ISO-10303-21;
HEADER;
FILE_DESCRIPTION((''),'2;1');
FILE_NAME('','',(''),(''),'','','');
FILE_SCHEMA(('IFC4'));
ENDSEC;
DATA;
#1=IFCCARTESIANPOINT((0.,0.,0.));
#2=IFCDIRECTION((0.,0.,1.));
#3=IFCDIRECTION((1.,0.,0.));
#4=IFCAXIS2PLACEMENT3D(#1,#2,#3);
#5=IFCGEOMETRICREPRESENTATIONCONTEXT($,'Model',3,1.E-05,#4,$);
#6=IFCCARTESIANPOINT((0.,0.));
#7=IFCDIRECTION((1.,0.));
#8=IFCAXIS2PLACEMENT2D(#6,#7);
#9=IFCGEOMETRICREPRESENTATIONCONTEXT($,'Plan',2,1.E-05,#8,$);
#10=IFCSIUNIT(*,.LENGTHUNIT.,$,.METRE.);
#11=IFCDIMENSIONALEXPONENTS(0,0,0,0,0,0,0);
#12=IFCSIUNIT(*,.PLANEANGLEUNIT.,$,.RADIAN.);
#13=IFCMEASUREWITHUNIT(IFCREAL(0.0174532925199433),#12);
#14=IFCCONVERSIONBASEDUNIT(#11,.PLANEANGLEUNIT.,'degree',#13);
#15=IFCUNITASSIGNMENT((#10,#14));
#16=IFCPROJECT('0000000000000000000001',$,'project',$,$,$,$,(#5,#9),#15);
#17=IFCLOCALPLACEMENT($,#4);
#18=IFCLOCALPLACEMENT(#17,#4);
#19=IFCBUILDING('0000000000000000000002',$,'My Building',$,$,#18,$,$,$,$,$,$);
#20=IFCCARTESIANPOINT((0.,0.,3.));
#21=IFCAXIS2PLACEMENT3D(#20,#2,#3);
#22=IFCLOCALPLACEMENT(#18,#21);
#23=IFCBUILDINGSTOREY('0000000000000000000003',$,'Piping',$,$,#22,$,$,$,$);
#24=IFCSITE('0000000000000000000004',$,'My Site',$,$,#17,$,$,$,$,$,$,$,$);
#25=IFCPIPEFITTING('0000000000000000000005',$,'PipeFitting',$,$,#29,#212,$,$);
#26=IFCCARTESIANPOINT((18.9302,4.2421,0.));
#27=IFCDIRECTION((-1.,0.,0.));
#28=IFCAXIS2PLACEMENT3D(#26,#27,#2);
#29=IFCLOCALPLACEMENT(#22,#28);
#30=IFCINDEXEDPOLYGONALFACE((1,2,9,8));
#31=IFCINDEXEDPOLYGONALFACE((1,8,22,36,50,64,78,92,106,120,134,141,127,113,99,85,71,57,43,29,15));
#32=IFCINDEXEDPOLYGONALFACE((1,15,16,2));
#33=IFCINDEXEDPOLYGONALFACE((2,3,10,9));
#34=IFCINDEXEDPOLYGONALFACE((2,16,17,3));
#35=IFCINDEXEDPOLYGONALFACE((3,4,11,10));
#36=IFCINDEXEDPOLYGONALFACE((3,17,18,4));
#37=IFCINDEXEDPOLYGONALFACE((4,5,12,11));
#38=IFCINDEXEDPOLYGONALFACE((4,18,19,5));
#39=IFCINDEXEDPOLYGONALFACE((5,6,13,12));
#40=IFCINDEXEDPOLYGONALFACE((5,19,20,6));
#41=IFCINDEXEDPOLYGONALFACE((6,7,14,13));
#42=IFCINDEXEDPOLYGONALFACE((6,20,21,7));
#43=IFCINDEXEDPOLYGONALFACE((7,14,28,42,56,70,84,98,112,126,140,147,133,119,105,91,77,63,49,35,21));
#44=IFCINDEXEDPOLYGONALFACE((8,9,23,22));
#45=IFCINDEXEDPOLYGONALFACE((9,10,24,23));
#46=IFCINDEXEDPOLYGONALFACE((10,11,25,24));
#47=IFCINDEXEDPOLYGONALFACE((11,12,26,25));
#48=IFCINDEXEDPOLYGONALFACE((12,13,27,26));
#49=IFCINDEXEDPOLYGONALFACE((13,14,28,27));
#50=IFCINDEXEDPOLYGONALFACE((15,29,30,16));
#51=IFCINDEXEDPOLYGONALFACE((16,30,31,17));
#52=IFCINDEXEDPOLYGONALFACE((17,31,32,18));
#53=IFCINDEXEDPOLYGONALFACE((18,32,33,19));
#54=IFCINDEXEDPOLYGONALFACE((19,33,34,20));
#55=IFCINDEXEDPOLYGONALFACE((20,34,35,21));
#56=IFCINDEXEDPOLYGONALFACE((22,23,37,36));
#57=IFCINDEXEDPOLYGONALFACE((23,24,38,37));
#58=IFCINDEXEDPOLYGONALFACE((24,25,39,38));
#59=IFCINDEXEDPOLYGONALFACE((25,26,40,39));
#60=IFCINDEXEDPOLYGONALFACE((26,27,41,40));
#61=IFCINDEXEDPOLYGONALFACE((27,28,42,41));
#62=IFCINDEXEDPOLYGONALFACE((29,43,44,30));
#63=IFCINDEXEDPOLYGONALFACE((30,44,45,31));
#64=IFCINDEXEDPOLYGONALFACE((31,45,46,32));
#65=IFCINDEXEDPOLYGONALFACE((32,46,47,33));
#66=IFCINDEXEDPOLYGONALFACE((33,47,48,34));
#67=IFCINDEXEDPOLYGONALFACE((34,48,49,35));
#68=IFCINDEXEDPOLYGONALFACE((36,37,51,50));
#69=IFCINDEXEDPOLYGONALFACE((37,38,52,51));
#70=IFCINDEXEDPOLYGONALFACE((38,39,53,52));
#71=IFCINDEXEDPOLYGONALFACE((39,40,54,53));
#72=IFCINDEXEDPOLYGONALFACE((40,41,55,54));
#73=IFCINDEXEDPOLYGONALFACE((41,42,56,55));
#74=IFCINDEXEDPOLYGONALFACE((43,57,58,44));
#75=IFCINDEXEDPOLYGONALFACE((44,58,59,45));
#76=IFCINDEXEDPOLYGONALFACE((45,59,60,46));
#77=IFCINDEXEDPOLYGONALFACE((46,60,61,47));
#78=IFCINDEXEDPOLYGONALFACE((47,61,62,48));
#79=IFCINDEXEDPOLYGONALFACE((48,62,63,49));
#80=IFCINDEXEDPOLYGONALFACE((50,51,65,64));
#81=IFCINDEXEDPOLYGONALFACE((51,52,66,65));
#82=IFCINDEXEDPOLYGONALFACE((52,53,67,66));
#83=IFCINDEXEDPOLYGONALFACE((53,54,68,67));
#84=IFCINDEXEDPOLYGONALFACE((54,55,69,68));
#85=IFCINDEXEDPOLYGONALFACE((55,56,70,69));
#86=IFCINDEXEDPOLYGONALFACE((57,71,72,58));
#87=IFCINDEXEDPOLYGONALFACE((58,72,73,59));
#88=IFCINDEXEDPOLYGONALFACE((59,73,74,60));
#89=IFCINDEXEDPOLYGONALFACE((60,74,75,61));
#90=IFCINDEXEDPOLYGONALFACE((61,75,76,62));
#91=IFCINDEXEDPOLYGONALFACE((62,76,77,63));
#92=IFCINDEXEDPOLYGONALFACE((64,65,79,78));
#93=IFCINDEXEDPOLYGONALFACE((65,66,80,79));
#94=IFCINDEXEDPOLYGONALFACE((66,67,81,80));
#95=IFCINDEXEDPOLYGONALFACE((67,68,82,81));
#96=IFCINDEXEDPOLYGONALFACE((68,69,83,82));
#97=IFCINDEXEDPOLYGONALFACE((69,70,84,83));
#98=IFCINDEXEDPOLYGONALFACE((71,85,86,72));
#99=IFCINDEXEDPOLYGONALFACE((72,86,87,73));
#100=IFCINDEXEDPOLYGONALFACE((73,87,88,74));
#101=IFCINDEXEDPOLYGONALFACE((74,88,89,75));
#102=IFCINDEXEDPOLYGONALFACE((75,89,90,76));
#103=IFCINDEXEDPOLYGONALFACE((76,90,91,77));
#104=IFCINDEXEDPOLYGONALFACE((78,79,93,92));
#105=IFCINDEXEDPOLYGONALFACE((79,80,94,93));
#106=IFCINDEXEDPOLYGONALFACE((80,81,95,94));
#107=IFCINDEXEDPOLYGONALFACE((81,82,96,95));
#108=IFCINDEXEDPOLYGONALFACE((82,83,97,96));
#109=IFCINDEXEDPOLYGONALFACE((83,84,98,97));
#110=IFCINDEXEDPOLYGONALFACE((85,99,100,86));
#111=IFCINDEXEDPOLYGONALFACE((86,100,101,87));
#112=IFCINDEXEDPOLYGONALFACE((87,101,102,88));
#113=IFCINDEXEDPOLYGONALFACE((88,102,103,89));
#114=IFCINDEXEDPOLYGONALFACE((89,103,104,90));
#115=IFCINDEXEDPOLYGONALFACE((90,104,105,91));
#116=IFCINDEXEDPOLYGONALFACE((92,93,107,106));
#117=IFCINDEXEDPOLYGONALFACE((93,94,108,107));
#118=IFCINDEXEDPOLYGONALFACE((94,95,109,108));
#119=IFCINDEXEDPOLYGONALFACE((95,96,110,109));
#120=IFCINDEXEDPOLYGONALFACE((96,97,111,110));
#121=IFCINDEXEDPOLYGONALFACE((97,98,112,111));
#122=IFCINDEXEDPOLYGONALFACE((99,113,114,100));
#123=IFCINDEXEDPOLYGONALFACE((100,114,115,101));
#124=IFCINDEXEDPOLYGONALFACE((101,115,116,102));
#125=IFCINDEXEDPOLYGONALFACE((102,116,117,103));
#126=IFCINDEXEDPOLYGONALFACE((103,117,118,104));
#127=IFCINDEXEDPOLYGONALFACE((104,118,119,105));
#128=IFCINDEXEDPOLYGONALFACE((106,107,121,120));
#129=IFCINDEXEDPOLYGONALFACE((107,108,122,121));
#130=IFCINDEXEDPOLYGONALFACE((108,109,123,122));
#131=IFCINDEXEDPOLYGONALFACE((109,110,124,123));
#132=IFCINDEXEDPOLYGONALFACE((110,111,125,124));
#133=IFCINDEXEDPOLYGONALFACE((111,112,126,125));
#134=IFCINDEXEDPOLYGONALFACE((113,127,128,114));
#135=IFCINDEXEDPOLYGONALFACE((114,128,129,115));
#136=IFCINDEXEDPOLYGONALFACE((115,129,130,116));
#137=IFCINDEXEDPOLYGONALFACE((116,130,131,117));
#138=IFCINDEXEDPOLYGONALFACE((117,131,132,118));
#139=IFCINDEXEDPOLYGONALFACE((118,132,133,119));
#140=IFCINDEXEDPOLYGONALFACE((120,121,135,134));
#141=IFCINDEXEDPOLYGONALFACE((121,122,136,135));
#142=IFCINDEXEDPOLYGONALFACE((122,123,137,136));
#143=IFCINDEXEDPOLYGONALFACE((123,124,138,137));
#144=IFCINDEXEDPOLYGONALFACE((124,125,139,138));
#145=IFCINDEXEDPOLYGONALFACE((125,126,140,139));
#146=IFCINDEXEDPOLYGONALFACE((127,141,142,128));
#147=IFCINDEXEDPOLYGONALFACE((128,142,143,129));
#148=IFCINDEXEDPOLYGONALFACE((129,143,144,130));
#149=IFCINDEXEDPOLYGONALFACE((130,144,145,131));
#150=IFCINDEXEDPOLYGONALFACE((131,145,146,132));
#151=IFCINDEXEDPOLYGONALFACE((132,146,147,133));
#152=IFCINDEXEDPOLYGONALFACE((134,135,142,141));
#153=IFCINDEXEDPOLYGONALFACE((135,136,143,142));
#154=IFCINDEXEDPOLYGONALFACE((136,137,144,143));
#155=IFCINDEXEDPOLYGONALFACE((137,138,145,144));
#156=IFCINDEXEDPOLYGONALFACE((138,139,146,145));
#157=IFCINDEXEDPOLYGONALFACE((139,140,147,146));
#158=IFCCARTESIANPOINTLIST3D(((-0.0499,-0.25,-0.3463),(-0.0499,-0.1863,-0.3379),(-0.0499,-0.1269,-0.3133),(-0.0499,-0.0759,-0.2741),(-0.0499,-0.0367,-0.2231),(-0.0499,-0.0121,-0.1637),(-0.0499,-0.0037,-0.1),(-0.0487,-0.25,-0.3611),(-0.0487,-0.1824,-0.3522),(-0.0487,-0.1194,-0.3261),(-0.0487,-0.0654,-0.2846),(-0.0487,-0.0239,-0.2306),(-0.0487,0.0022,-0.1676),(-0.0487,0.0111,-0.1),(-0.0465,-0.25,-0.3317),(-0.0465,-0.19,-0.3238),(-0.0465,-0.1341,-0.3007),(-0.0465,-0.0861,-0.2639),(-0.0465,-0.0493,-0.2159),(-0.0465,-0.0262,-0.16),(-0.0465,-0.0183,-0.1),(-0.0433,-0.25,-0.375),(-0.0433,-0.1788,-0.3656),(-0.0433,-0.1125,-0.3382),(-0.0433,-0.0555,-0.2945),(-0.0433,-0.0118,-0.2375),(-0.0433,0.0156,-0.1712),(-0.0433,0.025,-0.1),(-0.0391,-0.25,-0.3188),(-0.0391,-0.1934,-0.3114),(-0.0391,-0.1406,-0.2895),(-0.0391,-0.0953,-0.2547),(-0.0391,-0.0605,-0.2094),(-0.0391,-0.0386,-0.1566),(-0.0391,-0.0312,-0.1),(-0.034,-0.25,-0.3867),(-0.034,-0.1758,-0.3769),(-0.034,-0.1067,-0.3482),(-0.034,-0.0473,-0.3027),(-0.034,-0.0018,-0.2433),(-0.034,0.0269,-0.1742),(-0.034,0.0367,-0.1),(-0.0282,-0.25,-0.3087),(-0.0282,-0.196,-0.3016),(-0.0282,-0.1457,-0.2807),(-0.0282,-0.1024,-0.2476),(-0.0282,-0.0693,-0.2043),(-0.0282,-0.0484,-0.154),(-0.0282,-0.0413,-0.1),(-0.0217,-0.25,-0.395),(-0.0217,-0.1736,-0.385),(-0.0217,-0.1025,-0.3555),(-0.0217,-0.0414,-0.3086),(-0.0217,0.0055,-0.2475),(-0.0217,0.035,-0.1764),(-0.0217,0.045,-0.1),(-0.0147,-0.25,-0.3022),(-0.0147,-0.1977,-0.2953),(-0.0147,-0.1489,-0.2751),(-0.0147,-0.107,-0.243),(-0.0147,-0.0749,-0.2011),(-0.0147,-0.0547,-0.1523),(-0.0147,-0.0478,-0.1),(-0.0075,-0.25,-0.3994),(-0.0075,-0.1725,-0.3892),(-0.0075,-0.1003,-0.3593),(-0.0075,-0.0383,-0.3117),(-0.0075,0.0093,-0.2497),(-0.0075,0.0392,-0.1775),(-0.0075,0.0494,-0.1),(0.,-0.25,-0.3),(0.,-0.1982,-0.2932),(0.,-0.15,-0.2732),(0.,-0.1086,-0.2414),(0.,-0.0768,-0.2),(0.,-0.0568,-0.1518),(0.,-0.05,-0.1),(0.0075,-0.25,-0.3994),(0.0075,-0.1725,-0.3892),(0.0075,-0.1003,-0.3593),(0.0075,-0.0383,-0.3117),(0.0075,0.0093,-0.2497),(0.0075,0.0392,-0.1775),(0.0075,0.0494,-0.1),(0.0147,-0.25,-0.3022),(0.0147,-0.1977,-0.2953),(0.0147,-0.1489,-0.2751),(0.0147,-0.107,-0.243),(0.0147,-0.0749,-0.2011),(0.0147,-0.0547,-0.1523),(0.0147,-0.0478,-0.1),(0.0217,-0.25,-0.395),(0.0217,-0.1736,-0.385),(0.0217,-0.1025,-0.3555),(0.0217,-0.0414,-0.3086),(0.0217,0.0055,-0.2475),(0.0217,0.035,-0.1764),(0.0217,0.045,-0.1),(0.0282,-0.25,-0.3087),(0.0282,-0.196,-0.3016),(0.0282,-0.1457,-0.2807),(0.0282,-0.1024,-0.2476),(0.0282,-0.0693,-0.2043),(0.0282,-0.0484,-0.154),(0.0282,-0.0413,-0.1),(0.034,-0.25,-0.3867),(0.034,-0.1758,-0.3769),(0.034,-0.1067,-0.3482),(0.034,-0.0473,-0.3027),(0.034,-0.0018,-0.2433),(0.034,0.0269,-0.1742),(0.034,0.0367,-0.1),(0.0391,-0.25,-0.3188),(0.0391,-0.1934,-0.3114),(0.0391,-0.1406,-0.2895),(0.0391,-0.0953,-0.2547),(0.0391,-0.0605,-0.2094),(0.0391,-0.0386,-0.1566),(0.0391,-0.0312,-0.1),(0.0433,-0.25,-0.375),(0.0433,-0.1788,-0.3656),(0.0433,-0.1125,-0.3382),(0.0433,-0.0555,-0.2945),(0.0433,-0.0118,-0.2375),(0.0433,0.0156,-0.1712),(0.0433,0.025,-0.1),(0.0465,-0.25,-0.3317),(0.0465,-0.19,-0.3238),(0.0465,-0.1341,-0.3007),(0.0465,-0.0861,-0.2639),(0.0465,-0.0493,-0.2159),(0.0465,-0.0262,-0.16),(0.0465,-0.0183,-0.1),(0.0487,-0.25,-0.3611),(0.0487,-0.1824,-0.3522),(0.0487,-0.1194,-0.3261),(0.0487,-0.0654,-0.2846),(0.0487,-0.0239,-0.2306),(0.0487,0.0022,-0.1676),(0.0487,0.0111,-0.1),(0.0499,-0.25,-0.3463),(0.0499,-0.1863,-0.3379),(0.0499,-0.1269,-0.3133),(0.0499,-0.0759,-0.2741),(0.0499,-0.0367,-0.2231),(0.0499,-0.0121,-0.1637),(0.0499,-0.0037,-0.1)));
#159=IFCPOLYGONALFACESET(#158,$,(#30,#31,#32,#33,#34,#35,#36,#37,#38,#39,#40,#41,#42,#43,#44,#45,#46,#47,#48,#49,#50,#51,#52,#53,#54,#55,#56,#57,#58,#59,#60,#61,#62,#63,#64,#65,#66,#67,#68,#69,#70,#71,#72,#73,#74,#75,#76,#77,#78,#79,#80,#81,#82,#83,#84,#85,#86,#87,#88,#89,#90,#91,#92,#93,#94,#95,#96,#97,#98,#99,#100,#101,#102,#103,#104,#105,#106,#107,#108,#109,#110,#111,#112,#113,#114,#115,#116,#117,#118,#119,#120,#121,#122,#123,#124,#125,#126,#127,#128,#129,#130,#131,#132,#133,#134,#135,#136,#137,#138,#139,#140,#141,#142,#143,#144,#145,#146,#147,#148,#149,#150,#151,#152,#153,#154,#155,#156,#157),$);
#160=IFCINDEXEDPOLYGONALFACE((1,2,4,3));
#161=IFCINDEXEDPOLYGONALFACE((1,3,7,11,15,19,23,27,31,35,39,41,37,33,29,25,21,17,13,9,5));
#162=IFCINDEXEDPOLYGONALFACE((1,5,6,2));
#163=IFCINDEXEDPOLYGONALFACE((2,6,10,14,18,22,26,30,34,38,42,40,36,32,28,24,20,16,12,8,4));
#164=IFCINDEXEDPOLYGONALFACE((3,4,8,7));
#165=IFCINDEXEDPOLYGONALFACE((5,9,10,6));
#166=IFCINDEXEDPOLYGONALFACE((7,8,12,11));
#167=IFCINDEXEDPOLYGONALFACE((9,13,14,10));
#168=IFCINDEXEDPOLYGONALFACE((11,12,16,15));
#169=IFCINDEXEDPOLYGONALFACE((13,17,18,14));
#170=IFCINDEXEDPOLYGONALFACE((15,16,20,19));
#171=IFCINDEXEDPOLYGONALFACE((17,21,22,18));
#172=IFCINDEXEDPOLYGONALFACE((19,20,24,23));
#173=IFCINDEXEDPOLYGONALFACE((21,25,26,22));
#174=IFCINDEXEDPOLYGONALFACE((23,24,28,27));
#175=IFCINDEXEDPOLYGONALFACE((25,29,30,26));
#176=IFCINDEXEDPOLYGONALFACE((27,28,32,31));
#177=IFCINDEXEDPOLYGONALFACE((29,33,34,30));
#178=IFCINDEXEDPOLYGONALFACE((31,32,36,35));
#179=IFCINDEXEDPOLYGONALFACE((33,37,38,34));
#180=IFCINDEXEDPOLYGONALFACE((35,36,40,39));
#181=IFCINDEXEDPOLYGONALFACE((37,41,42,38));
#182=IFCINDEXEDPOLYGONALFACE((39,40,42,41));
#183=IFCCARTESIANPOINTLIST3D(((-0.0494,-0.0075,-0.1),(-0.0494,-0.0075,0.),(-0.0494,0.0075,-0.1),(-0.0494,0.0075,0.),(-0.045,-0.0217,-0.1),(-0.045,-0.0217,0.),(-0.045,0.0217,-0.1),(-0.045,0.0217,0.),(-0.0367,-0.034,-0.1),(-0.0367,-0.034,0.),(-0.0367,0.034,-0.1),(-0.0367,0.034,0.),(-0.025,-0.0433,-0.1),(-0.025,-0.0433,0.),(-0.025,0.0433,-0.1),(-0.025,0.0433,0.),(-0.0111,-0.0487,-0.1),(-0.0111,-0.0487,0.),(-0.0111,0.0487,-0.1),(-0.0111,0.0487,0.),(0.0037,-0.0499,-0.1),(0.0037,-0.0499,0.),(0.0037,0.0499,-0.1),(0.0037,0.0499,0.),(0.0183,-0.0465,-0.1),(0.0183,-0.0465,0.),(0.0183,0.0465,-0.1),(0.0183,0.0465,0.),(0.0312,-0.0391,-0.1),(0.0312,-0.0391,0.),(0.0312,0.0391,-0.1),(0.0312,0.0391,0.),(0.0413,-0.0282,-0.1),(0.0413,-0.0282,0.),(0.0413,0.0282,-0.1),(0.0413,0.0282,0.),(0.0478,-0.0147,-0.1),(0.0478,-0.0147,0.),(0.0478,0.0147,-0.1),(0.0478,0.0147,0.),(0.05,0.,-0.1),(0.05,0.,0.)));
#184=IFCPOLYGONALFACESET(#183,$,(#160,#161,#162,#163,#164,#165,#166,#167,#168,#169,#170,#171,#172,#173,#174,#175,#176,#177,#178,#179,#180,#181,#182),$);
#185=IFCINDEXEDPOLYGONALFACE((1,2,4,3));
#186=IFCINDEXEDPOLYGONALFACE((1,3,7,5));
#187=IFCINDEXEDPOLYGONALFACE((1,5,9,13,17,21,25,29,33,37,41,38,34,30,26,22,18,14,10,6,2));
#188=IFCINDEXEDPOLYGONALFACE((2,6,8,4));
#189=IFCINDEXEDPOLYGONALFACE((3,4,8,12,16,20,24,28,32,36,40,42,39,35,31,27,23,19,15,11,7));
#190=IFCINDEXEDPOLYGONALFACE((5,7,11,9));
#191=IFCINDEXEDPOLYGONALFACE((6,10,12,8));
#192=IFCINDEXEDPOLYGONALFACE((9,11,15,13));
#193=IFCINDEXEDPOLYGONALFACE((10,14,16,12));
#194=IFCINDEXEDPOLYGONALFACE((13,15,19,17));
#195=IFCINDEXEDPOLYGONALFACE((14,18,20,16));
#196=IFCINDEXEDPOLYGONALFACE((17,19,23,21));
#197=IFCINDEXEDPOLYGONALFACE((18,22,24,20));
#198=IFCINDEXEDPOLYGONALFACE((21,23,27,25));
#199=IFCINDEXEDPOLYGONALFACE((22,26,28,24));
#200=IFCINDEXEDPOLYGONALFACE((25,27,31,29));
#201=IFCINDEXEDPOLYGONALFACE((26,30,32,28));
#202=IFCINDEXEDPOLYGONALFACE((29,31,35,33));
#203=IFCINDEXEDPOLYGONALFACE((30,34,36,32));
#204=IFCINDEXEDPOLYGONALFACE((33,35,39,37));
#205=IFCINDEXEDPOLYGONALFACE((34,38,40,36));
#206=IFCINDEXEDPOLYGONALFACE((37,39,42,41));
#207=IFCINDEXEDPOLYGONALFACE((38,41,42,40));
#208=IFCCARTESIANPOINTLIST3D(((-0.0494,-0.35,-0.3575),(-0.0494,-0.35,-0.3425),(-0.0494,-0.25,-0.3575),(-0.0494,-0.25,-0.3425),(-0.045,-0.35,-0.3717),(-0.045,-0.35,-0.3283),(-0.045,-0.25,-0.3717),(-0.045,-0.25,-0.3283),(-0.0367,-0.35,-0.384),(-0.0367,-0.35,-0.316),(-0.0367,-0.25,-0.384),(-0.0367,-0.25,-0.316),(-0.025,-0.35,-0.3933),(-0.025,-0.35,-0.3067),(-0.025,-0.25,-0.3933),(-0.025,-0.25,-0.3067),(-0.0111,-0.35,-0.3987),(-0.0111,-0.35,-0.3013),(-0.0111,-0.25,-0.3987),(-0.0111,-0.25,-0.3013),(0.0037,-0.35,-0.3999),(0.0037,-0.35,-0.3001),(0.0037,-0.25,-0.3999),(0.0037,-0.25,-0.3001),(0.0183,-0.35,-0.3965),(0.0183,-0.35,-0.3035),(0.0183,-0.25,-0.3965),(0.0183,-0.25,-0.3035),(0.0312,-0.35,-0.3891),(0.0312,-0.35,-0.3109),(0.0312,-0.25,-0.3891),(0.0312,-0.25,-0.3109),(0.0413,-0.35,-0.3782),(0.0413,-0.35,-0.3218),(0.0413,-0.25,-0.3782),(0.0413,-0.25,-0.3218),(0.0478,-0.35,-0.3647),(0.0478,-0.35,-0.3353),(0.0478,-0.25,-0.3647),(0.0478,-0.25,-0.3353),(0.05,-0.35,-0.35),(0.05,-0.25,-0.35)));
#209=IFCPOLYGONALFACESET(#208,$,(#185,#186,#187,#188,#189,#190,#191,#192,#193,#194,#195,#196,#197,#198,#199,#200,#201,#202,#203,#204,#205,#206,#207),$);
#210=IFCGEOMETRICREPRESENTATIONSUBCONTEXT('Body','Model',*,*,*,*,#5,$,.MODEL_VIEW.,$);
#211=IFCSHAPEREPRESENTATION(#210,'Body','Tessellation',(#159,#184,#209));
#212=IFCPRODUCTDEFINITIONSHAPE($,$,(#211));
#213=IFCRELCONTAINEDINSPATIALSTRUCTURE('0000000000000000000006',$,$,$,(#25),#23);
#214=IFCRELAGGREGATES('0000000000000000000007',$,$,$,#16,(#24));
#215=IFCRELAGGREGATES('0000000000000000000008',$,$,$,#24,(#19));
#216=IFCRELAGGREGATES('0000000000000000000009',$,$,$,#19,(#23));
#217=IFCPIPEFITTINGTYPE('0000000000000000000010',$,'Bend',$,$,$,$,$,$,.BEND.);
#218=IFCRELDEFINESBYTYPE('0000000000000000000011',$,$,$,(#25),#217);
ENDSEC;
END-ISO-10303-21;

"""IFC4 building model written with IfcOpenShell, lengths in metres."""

from ifc_helpers import new_model, entity, si_unit, converted_unit, frame, origin_with_axes, origin_2d_with_axis, place, context, subcontext, project, spatial, circle, extrude, source, transform, mapped, type_object, type_shapes, element, save


model = new_model("IFC4")

# Units and contexts
model_context = context("Model", 3, precision=1e-05, world=origin_with_axes())
plan_context = context("Plan", 2, precision=1e-05, world=origin_2d_with_axis())
body_context = subcontext(model_context, "Body", "Model", "MODEL_VIEW")
ifc_project = project(units=[si_unit("LENGTHUNIT", "METRE"), converted_unit("PLANEANGLEUNIT", "degree", entity("IfcReal", 0.0174532925199433), si_unit("PLANEANGLEUNIT", "RADIAN"), dimensions=[0, 0, 0, 0, 0, 0, 0])], contexts=[model_context, plan_context])

# Site, building, storey
site_placement = place(None, origin_with_axes())
site = spatial("IfcSite", under=ifc_project, at=site_placement, Name="My Site")
building_placement = place(site_placement, origin_with_axes())
building = spatial("IfcBuilding", under=site, at=building_placement, Name="My Building")
storey_placement = place(building_placement, frame((0.0, 0.0, 3.0), z_axis=(0.0, 0.0, 1.0), x_axis=(1.0, 0.0, 0.0)))
storey = spatial("IfcBuildingStorey", under=building, at=storey_placement, Name="Piping")

# Pipe fitting
pipe_fitting_type = type_object("IfcPipeFittingType", Name="Bend", PredefinedType="BEND")
shared_shape = source(origin_with_axes(), body_context, "Body", "SolidModel", [
    entity("IfcSweptDiskSolid", entity("IfcIndexedPolyCurve", entity("IfcCartesianPointList3D", [[0.0, 0.0, -0.1], [0.0, -0.0732, -0.2768], [0.0, -0.25, -0.35]]), [entity("IfcArcIndex", [1, 2, 3])]), 0.05),
    extrude(circle(Radius=0.05), origin_with_axes(), (0.0, 0.0, -1.0), 0.1),
    extrude(circle(Radius=0.05), frame((0.0, -0.25, -0.35), z_axis=(0.0, -1.0, 0.0), x_axis=(1.0, 0.0, 0.0)), (0.0, 0.0, 1.0), 0.1),
])
type_shapes(pipe_fitting_type, [shared_shape])
for number, where, z_axis, x_axis, name in (
    (1, (18.9302, 4.2421, 0.0), (-1.0, 0.0, 0.0), (0.0, 0.0, 1.0), "PipeFitting"),
):
    element("IfcPipeFitting", number, at=place(storey_placement, frame(where, z_axis=z_axis, x_axis=x_axis)), inside=storey, type_object=pipe_fitting_type, Name=name, context=body_context, shape_type="MappedRepresentation", body=[
        mapped(shared_shape, transform((0.0, 0.0, 0.0), x_axis=(1.0, 0.0, 0.0), y_axis=(0.0, 1.0, 0.0), z_axis=(0.0, 0.0, 1.0), scale=1.0)),
    ])

save(model, "model.ifc")
